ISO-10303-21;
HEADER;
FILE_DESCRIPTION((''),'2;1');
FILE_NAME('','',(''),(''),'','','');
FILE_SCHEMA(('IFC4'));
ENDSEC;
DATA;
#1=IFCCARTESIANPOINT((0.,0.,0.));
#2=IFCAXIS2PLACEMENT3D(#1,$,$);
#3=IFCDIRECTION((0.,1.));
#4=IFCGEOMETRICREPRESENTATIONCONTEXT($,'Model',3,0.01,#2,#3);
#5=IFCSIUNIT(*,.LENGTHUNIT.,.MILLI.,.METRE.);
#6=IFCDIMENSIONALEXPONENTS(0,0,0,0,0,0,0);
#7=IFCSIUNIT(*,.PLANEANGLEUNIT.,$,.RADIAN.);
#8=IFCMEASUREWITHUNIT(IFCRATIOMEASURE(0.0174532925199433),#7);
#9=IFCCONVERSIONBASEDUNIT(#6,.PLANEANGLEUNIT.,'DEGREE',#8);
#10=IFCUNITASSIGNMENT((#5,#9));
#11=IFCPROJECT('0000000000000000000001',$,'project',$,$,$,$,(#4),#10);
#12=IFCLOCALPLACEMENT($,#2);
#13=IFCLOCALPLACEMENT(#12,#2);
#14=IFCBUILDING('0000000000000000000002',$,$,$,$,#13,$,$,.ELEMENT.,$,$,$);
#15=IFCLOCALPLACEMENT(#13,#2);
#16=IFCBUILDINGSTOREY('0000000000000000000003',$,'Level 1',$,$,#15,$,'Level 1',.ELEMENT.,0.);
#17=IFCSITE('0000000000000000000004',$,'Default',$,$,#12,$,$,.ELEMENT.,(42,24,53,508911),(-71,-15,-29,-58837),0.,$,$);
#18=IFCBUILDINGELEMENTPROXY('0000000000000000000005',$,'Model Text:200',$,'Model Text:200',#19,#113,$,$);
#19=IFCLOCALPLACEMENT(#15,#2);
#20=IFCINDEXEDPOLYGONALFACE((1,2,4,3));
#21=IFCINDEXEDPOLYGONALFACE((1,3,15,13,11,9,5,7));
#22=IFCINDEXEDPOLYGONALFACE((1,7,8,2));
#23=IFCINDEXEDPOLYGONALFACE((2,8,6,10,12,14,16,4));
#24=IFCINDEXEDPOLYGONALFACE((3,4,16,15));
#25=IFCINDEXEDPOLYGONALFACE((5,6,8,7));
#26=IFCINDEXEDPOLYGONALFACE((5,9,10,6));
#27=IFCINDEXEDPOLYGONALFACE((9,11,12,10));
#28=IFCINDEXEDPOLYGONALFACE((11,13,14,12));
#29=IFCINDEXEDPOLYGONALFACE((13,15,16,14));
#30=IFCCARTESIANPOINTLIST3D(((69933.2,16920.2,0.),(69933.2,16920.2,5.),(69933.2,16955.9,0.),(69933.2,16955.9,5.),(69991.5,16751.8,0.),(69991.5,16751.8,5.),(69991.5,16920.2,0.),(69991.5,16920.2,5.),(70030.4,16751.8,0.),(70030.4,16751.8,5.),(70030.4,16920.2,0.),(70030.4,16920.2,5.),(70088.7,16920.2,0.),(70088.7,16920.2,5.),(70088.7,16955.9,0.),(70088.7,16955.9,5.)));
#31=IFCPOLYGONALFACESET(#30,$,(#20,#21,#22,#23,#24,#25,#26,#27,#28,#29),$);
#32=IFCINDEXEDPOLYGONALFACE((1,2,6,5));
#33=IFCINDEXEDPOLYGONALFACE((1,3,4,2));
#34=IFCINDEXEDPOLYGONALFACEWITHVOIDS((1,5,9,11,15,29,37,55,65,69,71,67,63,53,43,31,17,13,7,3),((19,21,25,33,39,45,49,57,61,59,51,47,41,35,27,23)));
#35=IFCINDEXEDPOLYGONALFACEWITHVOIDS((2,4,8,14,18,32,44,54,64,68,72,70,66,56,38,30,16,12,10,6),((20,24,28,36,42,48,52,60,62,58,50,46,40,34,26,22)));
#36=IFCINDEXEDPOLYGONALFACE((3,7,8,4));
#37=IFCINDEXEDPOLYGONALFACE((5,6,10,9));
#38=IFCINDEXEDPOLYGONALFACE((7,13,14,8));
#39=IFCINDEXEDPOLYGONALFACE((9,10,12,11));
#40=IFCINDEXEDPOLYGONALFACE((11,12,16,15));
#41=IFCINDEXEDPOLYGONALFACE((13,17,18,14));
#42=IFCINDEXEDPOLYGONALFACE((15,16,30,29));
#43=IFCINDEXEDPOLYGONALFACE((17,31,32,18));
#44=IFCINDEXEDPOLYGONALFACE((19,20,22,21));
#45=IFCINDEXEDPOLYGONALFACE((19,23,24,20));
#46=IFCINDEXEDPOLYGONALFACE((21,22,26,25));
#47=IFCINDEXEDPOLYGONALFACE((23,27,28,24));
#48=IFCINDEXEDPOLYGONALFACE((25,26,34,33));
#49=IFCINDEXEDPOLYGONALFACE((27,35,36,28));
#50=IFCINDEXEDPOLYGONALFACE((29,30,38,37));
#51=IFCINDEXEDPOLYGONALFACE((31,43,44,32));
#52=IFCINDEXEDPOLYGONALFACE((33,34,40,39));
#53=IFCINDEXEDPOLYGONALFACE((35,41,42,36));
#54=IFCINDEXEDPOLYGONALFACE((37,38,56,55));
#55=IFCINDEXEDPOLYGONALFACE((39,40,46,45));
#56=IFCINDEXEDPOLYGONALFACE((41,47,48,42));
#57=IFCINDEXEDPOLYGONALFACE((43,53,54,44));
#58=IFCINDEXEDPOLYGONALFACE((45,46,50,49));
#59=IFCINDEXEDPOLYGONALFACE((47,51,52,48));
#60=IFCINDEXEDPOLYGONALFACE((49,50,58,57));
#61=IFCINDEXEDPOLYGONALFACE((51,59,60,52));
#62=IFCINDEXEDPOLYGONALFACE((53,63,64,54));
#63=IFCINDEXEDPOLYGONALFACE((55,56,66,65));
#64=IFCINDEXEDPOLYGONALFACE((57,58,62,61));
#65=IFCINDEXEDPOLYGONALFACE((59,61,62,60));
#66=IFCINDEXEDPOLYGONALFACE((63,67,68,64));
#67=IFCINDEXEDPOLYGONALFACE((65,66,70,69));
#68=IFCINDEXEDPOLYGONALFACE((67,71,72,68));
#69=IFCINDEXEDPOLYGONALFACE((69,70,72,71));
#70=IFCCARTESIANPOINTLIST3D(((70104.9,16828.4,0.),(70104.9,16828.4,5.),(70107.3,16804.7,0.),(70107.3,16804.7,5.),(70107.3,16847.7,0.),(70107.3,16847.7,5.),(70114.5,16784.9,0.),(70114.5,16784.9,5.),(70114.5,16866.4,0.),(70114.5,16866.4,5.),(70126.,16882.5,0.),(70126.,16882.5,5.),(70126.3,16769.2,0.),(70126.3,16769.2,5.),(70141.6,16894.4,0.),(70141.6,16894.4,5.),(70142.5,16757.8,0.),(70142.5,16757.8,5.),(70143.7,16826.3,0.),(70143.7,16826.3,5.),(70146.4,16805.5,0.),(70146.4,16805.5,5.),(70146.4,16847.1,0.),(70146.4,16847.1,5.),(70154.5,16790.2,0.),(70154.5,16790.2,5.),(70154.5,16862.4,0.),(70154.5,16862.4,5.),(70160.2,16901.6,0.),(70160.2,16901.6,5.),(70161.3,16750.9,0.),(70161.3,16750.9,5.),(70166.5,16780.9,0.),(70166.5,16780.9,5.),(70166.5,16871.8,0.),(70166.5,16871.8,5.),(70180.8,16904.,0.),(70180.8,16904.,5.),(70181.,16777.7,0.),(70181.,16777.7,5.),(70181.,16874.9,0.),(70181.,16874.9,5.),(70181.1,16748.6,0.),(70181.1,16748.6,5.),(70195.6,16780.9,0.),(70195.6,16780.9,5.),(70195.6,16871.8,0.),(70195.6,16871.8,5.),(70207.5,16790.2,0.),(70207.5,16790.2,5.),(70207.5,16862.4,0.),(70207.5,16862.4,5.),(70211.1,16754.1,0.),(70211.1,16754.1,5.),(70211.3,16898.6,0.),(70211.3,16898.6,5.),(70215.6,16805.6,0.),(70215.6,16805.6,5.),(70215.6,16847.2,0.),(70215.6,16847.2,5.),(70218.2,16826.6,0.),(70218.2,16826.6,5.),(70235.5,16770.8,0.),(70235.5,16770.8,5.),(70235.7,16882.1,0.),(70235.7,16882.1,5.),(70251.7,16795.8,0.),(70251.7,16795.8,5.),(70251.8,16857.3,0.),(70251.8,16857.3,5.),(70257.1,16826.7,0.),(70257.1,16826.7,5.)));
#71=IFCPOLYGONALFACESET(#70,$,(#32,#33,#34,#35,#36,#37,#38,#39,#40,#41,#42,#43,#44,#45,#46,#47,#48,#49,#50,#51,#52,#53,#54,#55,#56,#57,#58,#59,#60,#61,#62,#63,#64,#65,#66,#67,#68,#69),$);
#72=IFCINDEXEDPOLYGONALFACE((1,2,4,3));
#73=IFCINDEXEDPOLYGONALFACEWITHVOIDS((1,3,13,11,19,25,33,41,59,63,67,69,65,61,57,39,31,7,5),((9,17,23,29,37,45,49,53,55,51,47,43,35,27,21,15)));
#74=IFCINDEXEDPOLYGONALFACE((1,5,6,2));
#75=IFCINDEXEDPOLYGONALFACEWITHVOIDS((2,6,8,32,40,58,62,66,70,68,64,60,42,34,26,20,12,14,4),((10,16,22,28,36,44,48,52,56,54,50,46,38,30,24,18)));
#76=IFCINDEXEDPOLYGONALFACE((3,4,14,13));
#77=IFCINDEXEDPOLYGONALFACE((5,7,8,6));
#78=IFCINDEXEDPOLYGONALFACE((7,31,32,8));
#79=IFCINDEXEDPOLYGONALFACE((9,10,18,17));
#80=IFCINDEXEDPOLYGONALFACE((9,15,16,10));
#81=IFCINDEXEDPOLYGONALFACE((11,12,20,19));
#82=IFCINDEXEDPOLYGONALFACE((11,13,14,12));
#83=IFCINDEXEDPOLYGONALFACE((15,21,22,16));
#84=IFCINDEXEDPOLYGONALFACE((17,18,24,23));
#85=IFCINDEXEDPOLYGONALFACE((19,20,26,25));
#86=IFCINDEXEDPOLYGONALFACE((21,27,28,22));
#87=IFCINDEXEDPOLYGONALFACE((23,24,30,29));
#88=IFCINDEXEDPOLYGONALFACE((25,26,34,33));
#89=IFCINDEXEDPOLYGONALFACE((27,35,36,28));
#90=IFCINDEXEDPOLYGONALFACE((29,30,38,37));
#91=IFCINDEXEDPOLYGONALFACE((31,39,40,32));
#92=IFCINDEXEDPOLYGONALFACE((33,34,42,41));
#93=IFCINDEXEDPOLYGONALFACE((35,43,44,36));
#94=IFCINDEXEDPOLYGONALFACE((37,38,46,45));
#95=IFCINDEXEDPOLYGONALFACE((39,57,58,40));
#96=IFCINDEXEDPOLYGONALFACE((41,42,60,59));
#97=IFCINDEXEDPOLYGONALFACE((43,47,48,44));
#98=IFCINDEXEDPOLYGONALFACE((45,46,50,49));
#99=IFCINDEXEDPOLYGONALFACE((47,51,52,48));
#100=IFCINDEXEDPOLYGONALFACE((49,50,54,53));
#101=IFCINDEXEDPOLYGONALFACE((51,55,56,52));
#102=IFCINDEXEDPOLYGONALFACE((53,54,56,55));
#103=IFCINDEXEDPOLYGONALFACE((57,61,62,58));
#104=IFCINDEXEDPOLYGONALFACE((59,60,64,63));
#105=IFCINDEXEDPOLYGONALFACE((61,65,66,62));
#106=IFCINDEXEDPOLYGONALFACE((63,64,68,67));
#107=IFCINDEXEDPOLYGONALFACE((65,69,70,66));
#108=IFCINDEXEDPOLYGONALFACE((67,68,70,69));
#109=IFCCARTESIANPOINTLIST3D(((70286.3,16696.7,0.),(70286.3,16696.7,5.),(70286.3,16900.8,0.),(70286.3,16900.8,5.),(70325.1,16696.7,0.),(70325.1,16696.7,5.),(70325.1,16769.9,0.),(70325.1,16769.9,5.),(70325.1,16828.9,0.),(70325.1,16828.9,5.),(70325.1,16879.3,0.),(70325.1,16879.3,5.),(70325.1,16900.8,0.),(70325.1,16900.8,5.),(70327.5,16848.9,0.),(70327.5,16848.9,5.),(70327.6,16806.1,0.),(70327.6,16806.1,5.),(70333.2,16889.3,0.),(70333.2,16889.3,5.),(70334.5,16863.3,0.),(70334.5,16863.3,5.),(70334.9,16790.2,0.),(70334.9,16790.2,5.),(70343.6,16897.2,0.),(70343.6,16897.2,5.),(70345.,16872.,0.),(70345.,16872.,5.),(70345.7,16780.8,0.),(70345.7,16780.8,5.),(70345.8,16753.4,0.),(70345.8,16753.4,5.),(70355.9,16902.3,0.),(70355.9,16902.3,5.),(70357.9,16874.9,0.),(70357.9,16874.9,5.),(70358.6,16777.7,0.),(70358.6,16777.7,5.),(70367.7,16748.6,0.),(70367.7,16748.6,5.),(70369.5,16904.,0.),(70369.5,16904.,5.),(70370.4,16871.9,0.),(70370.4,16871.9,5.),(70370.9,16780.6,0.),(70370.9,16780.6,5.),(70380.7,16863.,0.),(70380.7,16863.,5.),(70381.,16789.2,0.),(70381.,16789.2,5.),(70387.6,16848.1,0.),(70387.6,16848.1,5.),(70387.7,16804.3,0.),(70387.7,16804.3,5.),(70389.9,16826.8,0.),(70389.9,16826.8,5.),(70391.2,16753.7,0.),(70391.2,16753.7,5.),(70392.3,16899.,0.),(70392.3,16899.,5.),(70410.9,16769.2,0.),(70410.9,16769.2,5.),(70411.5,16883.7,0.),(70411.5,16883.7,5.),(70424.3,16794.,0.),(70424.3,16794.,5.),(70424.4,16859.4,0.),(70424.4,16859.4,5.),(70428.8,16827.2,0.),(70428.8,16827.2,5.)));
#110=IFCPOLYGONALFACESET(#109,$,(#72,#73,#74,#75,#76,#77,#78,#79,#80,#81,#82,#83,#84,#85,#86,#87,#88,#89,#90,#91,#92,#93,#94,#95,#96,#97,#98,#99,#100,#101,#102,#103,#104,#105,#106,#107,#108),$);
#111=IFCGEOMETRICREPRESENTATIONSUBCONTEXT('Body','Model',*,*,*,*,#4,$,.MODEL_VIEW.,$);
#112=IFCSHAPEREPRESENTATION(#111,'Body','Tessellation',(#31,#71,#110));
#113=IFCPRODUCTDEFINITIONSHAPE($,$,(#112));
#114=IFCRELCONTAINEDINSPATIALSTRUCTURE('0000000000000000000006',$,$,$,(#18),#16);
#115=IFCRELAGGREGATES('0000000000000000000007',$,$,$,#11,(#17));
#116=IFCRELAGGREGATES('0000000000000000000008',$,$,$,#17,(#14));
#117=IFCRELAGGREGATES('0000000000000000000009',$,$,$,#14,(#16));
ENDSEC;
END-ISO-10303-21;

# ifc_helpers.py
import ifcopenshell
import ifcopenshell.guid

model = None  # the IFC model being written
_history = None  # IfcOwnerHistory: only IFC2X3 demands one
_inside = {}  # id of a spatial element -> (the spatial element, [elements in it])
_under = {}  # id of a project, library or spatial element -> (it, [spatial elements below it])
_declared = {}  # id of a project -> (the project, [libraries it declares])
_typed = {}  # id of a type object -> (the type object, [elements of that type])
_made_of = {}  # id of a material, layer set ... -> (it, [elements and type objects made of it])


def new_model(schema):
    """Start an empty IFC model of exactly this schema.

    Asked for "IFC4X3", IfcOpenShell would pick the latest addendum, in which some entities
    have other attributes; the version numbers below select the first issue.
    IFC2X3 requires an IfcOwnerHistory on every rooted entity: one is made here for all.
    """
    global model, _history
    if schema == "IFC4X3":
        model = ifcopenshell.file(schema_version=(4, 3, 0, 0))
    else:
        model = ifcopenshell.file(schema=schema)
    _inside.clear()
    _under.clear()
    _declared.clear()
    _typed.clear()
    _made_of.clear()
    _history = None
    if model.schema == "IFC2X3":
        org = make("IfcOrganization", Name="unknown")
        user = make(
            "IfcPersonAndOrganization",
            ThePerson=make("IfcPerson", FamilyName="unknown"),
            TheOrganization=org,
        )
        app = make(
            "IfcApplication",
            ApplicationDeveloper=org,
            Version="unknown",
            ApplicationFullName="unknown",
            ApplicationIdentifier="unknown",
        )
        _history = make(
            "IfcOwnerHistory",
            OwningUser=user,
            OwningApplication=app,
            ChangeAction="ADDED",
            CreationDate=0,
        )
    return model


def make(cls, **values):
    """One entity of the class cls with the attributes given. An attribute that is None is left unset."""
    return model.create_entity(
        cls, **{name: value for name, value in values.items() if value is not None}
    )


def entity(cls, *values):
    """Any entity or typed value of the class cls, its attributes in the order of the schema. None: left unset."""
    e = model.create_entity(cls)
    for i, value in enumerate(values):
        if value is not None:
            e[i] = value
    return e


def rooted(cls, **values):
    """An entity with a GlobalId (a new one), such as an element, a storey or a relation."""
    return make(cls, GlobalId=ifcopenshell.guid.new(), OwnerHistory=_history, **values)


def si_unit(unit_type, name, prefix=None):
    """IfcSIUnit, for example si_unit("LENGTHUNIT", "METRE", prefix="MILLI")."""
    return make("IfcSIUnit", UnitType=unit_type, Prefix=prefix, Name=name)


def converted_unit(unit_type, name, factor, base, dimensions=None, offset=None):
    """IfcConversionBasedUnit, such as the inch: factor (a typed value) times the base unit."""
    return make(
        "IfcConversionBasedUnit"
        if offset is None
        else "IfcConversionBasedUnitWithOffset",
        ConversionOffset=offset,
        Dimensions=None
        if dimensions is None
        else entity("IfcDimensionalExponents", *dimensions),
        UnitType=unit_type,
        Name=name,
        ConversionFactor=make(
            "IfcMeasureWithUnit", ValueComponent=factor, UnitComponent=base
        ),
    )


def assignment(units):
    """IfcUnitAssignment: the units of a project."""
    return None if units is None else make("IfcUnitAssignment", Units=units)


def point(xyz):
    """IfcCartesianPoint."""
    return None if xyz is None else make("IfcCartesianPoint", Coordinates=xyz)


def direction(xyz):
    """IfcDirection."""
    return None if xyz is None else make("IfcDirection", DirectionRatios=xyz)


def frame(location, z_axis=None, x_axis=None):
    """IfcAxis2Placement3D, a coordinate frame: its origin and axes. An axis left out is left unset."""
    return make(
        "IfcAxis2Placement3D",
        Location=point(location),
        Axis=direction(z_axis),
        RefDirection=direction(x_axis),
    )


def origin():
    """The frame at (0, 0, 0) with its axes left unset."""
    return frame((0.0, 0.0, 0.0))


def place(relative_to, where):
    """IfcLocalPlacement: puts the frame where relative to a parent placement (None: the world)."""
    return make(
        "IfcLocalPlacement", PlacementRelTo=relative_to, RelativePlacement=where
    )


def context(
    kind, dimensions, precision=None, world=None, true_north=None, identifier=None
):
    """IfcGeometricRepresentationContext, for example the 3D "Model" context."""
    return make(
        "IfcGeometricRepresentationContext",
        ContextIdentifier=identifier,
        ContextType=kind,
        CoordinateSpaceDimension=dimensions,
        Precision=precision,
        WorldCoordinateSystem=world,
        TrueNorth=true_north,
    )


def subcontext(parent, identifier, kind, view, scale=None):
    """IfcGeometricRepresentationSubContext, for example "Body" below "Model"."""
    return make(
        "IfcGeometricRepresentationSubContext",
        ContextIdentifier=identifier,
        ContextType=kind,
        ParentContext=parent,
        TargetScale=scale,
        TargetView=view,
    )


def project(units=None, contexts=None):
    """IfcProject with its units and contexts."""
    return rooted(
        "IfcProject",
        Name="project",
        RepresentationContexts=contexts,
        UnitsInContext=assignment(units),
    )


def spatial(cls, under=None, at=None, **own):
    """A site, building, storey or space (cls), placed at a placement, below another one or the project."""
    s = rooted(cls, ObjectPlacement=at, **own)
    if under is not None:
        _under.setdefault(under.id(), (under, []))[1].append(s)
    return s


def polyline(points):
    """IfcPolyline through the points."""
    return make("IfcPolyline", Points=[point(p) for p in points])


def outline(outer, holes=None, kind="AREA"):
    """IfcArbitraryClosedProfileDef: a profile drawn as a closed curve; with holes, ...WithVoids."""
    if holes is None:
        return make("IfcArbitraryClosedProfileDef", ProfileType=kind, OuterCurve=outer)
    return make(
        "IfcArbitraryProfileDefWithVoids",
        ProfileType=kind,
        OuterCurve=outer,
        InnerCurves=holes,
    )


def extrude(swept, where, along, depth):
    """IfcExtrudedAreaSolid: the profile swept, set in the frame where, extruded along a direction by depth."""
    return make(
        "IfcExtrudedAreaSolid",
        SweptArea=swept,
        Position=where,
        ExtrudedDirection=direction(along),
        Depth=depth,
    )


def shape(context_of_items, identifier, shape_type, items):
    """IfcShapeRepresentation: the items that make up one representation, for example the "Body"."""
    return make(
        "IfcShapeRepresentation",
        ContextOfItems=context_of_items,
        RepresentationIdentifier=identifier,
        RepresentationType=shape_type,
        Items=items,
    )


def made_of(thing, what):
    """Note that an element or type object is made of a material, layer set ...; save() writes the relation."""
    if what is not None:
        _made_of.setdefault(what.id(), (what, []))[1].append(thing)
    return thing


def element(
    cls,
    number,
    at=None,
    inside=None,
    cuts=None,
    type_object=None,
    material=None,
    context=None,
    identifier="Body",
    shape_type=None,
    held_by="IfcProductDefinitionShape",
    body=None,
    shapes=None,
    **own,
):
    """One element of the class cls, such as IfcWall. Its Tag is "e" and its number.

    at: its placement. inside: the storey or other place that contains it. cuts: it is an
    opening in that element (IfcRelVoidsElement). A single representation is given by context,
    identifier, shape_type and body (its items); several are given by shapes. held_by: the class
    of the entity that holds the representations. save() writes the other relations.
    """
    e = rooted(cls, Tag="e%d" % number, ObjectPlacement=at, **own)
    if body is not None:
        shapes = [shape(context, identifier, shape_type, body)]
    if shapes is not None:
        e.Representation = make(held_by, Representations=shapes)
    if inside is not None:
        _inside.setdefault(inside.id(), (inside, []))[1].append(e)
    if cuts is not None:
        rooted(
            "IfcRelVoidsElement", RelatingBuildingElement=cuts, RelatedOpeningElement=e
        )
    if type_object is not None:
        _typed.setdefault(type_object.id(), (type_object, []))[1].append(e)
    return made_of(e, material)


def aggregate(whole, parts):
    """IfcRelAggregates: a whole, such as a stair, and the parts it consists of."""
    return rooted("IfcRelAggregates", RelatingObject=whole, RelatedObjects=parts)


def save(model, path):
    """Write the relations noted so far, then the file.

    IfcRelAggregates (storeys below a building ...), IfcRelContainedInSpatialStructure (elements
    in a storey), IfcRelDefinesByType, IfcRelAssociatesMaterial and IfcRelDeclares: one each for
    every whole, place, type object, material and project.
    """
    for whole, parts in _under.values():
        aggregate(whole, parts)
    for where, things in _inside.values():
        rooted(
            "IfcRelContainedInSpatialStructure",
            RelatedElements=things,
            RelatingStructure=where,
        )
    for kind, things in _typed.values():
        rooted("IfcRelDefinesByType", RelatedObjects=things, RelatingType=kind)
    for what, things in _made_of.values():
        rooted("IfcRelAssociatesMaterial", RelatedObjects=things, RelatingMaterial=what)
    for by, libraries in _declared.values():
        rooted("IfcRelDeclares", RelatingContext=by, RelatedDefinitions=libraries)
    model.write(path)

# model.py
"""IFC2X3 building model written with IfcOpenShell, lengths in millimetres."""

from ifc_helpers import new_model, entity, si_unit, converted_unit, direction, frame, origin, place, context, subcontext, project, spatial, polyline, outline, extrude, element, save


model = new_model("IFC2X3")

# Units and contexts
model_context = context("Model", 3, precision=0.01, world=origin(), true_north=direction((0.0, 1.0)))
body_context = subcontext(model_context, "Body", "Model", "MODEL_VIEW")
ifc_project = project(units=[si_unit("LENGTHUNIT", "METRE", prefix="MILLI"), converted_unit("PLANEANGLEUNIT", "DEGREE", entity("IfcRatioMeasure", 0.0174532925199433), si_unit("PLANEANGLEUNIT", "RADIAN"), dimensions=[0, 0, 0, 0, 0, 0, 0])], contexts=[model_context])

# Site, building, storey
site_placement = place(None, origin())
site = spatial("IfcSite", under=ifc_project, at=site_placement, Name="Default", CompositionType="ELEMENT", RefLatitude=(42, 24, 53, 508911), RefLongitude=(-71, -15, -29, -58837), RefElevation=0.0)
building_placement = place(site_placement, origin())
building = spatial("IfcBuilding", under=site, at=building_placement, CompositionType="ELEMENT")
storey_placement = place(building_placement, origin())
storey = spatial("IfcBuildingStorey", under=building, at=storey_placement, Name="Level 1", LongName="Level 1", CompositionType="ELEMENT", Elevation=0.0)

# Building element proxy
proxy_1_placement = place(storey_placement, origin())
element("IfcBuildingElementProxy", 1, at=proxy_1_placement, inside=storey, Name="Model Text:200", ObjectType="Model Text:200", context=body_context, shape_type="SweptSolid", body=[
    extrude(outline(polyline([(-19.4, -135.2), (19.4, -135.2), (19.4, 33.2), (77.7, 33.2), (77.7, 68.8), (-77.7, 68.8), (-77.7, 33.2), (-19.4, 33.2), (-19.4, -135.2)])), frame((70010.9, 16887.0, 0.0)), (0.0, 0.0, 1.0), 5.0),
    extrude(outline(polyline([(-8.8, -65.7), (15.1, -65.7), (35.5, -60.5), (52.3, -50.4), (65.3, -35.4), (74.1, -17.3), (78.4, 2.1), (75.9, 32.5), (61.8, 58.5), (38.4, 77.1), (8.3, 85.6), (-22.7, 83.3), (-49.0, 69.9), (-67.8, 47.3), (-76.3, 17.5), (-76.0, -3.3), (-70.7, -22.5), (-60.5, -39.2), (-45.5, -52.3), (-27.7, -61.4), (-8.8, -65.7)]), holes=[polyline([(-2.7, -27.2), (-23.1, -22.5), (-37.5, -12.9), (-45.7, 0.0), (-47.3, 14.8), (-42.7, 28.9), (-32.2, 39.9), (-16.3, 46.3), (4.5, 46.9), (25.1, 42.1), (39.6, 32.6), (47.7, 19.7), (49.4, 5.0), (44.8, -9.2), (34.2, -20.2), (18.2, -26.7), (-2.7, -27.2)])]), frame((70171.1, 16826.3, 0.0), z_axis=(0.0, 0.0, 1.0), x_axis=(0.100608, -0.994926, 0.0)), (0.0, 0.0, 1.0), 5.0),
    extrude(outline(polyline([(-73.1, -75.4), (130.9, -75.4), (130.9, -36.6), (57.8, -36.6), (74.3, -15.9), (79.1, 6.0), (73.9, 29.5), (58.4, 49.2), (33.6, 62.6), (0.5, 67.1), (-31.8, 62.8), (-56.1, 49.8), (-71.3, 30.7), (-76.4, 7.8), (-74.7, -5.8), (-69.6, -18.1), (-61.7, -28.5), (-51.7, -36.6), (-73.1, -36.6), (-73.1, -75.4)]), holes=[polyline([(-1.2, -36.6), (-21.2, -34.2), (-35.6, -27.2), (-44.3, -16.7), (-47.2, -3.8), (-44.3, 8.7), (-35.4, 19.0), (-20.4, 25.9), (0.8, 28.2), (23.3, 26.0), (38.5, 19.3), (47.1, 9.2), (49.9, -3.1), (46.8, -16.0), (37.4, -26.8), (21.5, -34.1), (-1.2, -36.6)])]), frame((70361.7, 16827.7, 0.0), z_axis=(0.0, 0.0, 1.0), x_axis=(0.0, -1.0, 0.0)), (0.0, 0.0, 1.0), 5.0),
])

save(model, "model.ifc")
